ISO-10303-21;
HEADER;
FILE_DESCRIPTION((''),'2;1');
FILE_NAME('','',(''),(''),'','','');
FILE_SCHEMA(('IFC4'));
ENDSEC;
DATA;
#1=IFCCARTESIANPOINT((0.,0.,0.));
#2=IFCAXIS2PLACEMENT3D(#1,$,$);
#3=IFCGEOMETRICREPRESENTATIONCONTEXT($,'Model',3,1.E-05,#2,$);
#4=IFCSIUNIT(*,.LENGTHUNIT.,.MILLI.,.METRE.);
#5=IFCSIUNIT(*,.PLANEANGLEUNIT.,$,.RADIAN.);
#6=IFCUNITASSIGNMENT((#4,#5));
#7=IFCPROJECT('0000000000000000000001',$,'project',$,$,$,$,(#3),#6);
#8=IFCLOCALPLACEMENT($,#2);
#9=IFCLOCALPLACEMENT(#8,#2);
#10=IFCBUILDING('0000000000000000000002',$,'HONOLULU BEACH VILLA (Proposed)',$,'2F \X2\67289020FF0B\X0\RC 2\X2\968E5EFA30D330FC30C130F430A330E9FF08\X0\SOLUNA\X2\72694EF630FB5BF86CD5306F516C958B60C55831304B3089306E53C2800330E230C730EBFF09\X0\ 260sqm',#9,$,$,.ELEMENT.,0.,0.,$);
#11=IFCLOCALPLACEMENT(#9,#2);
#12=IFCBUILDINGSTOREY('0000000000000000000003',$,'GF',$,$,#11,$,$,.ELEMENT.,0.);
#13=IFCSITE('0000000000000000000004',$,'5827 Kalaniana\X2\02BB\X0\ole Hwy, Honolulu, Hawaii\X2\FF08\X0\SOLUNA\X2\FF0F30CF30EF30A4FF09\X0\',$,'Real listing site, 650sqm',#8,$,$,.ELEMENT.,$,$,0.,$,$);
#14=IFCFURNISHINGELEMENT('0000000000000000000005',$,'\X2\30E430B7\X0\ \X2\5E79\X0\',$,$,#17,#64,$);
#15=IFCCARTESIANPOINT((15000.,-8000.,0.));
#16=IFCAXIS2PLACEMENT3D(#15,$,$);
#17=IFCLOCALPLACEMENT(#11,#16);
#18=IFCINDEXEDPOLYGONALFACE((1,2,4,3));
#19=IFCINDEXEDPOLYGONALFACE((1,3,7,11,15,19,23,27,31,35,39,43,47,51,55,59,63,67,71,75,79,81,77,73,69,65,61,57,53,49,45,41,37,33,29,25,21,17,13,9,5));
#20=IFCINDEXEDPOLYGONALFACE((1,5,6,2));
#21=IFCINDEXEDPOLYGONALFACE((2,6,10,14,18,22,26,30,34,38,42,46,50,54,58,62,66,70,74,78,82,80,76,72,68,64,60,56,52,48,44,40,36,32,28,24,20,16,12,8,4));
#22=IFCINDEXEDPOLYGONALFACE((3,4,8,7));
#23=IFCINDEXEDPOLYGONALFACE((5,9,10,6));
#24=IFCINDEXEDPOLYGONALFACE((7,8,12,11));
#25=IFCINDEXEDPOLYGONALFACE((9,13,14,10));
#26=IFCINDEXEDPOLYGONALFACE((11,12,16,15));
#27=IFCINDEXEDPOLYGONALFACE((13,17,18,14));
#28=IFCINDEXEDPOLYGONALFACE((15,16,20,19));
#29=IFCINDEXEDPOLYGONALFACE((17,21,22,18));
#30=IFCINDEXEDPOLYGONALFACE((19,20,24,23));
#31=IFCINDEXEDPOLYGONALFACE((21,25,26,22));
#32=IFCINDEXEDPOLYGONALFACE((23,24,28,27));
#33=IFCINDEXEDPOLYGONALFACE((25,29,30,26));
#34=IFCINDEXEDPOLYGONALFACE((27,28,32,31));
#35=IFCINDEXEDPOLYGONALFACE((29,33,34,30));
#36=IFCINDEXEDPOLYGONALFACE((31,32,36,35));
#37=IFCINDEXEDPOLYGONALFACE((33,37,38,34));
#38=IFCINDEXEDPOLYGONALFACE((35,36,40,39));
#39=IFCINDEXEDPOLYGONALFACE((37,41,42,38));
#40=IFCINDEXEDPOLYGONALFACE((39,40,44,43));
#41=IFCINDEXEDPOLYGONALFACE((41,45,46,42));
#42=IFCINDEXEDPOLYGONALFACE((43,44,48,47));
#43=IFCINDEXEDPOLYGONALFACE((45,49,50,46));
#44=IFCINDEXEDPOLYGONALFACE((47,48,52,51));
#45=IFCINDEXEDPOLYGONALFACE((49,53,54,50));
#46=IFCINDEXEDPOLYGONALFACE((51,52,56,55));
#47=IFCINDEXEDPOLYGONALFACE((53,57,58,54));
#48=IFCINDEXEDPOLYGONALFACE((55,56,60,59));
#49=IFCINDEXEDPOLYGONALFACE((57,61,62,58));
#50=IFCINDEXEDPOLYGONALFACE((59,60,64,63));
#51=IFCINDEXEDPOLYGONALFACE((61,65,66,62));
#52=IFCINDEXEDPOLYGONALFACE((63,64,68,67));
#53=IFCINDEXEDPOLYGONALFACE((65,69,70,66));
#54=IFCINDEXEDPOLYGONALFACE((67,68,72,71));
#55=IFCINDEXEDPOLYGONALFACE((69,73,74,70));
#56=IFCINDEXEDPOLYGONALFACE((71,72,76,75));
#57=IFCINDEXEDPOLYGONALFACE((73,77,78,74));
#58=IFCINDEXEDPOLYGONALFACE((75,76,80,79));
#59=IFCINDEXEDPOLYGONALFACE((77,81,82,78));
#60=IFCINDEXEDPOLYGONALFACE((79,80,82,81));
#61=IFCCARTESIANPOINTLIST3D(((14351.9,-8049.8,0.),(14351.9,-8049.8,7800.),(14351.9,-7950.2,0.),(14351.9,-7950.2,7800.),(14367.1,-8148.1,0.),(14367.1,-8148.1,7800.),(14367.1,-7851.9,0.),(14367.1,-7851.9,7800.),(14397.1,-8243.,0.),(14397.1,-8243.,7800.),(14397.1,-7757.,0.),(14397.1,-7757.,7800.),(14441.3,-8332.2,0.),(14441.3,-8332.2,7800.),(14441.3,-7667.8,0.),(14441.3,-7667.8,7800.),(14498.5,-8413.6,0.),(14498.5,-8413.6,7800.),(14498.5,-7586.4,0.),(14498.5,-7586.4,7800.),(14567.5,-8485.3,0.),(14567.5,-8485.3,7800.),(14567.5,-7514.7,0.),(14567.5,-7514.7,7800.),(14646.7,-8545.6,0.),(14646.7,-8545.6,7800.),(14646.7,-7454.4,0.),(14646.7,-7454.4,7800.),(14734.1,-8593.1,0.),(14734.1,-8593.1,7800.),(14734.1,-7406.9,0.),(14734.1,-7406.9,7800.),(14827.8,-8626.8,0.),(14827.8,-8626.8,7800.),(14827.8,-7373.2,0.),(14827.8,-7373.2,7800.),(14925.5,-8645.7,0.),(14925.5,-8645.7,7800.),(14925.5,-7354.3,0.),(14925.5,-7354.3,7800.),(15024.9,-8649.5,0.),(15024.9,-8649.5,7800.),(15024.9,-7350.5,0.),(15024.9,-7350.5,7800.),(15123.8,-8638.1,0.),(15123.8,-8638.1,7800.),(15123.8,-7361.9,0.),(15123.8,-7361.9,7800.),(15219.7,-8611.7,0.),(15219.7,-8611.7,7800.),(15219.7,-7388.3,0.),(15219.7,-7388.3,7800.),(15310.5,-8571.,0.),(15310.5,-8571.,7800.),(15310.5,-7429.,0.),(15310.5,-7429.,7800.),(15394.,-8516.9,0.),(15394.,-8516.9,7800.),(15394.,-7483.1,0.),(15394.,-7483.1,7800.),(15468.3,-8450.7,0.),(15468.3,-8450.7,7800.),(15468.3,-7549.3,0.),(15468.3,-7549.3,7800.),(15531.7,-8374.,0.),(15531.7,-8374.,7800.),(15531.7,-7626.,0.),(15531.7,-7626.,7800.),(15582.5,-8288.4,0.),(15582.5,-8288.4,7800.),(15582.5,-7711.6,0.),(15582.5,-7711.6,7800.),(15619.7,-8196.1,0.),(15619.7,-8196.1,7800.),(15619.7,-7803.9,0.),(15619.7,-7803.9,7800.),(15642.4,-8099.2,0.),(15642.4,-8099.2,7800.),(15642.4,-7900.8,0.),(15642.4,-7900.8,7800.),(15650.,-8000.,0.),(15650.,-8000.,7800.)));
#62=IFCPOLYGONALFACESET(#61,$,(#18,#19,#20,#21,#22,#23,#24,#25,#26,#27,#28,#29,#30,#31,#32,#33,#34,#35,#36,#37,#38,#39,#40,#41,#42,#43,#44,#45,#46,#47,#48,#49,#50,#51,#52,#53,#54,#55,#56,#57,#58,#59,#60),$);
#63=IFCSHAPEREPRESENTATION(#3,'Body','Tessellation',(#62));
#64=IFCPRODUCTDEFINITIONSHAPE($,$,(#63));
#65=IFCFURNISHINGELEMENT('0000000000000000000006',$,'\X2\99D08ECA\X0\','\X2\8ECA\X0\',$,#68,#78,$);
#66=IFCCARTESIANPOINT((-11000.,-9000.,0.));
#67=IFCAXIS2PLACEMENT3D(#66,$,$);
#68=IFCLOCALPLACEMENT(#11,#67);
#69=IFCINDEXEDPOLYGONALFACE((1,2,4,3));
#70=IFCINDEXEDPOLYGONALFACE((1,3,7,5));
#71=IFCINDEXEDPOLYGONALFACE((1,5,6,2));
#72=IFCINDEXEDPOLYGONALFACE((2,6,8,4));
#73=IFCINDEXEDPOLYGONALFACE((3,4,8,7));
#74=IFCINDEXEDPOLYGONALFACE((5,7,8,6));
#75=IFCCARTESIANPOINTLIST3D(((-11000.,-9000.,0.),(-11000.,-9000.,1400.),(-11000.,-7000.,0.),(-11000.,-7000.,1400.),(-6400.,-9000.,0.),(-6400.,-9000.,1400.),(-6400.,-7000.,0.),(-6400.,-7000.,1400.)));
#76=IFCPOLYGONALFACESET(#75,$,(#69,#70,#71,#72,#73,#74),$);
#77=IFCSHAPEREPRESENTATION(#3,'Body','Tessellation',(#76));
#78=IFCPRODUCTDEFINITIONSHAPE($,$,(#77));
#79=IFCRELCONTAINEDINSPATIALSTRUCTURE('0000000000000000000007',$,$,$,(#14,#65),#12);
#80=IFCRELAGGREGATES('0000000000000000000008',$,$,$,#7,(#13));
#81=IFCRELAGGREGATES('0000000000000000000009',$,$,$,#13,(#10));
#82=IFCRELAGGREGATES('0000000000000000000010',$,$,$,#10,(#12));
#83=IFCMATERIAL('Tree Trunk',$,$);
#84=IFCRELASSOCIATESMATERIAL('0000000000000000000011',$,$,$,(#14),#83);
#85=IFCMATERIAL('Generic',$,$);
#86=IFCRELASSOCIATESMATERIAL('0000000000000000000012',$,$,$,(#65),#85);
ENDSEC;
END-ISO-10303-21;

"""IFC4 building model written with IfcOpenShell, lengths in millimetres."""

from ifc_helpers import new_model, si_unit, frame, frame_2d, origin, origin_2d, place, context, project, spatial, rectangle, circle, extrude, material, element, save


model = new_model("IFC4")

# Units and contexts
model_context = context("Model", 3, precision=1e-05, world=origin())
ifc_project = project(units=[si_unit("LENGTHUNIT", "METRE", prefix="MILLI"), si_unit("PLANEANGLEUNIT", "RADIAN")], contexts=[model_context])

# Site, building, storey
site_placement = place(None, origin())
site = spatial("IfcSite", under=ifc_project, at=site_placement, Name="5827 Kalanianaʻole Hwy, Honolulu, Hawaii（SOLUNA／ハワイ）", ObjectType="Real listing site, 650sqm", CompositionType="ELEMENT", RefElevation=0.0)
building_placement = place(site_placement, origin())
building = spatial("IfcBuilding", under=site, at=building_placement, Name="HONOLULU BEACH VILLA (Proposed)", ObjectType="2F 木造＋RC 2階建ビーチヴィラ（SOLUNA物件・寸法は公開情報からの参考モデル） 260sqm", CompositionType="ELEMENT", ElevationOfRefHeight=0.0, ElevationOfTerrain=0.0)
storey_placement = place(building_placement, origin())
storey = spatial("IfcBuildingStorey", under=building, at=storey_placement, Name="GF", CompositionType="ELEMENT", Elevation=0.0)

# Shared definitions
ifc_material_1 = material(Name="Generic")

# Furnishing elements
ifc_material_2 = material(Name="Tree Trunk")
furnishing_1_placement = place(storey_placement, frame((15000.0, -8000.0, 0.0)))
element("IfcFurnishingElement", 1, at=furnishing_1_placement, inside=storey, material=ifc_material_2, Name="ヤシ 幹", context=model_context, shape_type="SweptSolid", body=[
    extrude(circle(Radius=650.0, at=origin_2d()), frame((15000.0, -8000.0, 0.0)), (0.0, 0.0, 1.0), 7800.0),
])
furnishing_2_placement = place(storey_placement, frame((-11000.0, -9000.0, 0.0)))
element("IfcFurnishingElement", 2, at=furnishing_2_placement, inside=storey, material=ifc_material_1, Name="駐車", Description="車", context=model_context, shape_type="SweptSolid", body=[
    extrude(rectangle(XDim=4600.0, YDim=2000.0, at=frame_2d((2300.0, 1000.0))), frame((-11000.0, -9000.0, 0.0)), (0.0, 0.0, 1.0), 1400.0),
])

save(model, "model.ifc")
